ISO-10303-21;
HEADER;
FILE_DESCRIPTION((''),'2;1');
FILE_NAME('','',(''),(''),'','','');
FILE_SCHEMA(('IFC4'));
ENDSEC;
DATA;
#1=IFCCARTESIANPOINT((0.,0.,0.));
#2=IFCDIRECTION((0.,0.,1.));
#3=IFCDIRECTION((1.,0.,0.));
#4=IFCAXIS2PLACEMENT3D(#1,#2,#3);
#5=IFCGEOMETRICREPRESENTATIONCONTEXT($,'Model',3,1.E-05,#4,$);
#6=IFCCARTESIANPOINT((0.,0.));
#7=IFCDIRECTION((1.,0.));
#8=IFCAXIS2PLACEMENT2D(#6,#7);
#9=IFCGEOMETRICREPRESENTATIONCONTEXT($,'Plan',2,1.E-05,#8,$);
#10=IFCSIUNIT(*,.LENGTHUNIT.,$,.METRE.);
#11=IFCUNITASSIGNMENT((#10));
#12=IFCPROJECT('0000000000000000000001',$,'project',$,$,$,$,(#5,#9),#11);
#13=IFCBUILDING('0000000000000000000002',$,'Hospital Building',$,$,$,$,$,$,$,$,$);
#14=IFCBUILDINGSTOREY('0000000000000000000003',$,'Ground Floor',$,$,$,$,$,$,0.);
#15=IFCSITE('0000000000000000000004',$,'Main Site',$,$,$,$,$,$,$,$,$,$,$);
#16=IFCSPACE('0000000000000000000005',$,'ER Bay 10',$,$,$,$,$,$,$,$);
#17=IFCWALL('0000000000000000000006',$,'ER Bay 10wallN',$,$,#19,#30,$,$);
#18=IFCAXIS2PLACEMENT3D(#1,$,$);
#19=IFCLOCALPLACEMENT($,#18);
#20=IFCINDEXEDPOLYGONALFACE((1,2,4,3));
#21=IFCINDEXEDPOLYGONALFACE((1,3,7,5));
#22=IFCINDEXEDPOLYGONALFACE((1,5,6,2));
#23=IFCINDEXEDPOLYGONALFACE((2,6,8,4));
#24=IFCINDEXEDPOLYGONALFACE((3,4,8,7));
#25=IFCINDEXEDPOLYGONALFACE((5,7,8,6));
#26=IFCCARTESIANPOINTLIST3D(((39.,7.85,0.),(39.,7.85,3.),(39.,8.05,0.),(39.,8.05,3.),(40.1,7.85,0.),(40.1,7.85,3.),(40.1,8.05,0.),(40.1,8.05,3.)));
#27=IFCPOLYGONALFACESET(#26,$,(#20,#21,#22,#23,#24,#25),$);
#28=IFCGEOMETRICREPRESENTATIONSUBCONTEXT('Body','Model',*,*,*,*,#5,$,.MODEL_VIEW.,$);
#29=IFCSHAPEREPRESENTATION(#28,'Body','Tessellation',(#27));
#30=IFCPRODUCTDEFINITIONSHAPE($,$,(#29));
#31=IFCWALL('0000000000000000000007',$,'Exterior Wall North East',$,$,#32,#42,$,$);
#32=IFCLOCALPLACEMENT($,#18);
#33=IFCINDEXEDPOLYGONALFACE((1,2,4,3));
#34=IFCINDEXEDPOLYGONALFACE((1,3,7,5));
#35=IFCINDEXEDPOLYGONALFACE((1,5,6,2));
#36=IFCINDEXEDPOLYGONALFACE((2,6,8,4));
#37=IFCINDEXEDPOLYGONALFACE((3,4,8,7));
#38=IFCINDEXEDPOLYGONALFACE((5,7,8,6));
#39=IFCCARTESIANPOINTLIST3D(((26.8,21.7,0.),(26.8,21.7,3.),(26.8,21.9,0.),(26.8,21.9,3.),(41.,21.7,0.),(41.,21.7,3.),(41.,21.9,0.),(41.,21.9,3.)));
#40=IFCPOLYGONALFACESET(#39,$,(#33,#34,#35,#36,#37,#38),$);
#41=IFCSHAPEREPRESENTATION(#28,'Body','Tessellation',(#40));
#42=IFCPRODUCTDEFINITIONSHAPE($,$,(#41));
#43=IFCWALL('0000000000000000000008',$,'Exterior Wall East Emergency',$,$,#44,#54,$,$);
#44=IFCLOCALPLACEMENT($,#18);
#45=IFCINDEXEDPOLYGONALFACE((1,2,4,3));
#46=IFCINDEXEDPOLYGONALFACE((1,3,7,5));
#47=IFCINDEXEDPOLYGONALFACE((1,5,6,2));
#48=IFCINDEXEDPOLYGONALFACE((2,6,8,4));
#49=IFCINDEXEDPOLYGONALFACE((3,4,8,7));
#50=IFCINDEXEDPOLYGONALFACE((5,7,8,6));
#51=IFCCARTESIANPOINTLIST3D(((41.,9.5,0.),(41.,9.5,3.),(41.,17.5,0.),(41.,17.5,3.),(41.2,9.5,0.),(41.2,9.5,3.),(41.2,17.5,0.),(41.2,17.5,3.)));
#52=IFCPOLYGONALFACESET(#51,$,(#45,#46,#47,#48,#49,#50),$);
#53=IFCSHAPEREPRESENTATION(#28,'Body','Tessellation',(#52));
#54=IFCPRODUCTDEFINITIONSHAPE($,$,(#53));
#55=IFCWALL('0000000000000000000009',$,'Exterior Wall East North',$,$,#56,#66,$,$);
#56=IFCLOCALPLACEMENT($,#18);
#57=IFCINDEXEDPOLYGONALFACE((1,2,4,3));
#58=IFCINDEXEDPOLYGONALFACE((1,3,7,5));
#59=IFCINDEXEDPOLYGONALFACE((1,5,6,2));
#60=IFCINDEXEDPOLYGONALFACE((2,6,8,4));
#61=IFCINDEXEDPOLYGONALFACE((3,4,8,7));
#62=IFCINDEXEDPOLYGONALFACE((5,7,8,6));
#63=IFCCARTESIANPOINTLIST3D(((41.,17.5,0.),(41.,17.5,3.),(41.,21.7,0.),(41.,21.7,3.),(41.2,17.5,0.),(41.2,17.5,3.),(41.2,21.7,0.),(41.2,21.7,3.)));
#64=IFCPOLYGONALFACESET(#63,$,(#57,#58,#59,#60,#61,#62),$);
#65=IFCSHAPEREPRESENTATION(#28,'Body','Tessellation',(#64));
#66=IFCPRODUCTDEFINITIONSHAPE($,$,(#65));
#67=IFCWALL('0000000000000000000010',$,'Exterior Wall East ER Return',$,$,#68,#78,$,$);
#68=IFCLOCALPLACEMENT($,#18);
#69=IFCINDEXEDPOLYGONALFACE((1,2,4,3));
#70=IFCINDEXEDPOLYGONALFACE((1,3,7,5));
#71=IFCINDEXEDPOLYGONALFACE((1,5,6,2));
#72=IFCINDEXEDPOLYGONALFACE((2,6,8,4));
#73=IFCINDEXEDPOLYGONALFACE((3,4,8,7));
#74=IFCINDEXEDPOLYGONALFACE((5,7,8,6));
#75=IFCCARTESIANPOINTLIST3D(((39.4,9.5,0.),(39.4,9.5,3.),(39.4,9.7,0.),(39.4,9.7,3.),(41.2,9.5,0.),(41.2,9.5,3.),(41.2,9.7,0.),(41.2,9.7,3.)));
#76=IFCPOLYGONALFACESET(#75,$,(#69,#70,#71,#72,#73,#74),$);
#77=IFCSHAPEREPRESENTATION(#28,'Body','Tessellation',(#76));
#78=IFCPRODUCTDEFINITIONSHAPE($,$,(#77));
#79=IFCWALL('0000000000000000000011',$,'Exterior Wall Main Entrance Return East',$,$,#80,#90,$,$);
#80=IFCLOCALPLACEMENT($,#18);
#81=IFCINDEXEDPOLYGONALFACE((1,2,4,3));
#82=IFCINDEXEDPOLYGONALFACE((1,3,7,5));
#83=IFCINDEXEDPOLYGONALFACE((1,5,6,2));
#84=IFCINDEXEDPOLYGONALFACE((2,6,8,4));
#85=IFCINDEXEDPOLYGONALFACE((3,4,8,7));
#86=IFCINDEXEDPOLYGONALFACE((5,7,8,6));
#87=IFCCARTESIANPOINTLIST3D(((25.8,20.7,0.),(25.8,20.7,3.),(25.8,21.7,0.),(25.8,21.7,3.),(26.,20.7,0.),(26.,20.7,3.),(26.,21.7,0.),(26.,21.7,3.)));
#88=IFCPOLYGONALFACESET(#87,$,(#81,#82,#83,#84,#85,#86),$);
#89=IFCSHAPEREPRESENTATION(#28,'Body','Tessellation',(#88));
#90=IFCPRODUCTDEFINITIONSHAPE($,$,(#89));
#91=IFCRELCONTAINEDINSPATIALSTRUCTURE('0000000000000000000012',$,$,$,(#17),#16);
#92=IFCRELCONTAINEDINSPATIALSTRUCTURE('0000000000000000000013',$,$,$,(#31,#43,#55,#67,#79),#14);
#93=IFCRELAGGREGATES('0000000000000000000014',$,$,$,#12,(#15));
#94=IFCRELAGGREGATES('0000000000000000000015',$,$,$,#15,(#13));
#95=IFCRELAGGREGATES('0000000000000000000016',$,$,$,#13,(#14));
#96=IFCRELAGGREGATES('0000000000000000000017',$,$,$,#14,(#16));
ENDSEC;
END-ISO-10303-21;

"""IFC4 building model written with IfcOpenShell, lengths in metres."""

from ifc_helpers import new_model, si_unit, frame, origin_with_axes, origin_2d_with_axis, place, context, subcontext, project, spatial, indexed_curve, outline, extrude, element, save


model = new_model("IFC4")

# Units and contexts
model_context = context("Model", 3, precision=1e-05, world=origin_with_axes())
plan_context = context("Plan", 2, precision=1e-05, world=origin_2d_with_axis())
body_context = subcontext(model_context, "Body", "Model", "MODEL_VIEW")
ifc_project = project(units=[si_unit("LENGTHUNIT", "METRE")], contexts=[model_context, plan_context])

# Site, building, storey
site = spatial("IfcSite", under=ifc_project, Name="Main Site")
building = spatial("IfcBuilding", under=site, Name="Hospital Building")
storey = spatial("IfcBuildingStorey", under=building, Name="Ground Floor", Elevation=0.0)

# Shared definitions
space_1 = spatial("IfcSpace", under=storey, Name="ER Bay 10")

# Walls
wall_1_placement = place(None, frame((39.0, 7.85, 0.0), z_axis=(0.0, 0.0, 1.0), x_axis=(1.0, 0.0, 0.0)))
element("IfcWall", 1, at=wall_1_placement, inside=space_1, Name="ER Bay 10wallN", context=body_context, shape_type="SweptSolid", body=[
    extrude(outline(indexed_curve([(0.0, 0.0), (0.0, 0.2), (1.1, 0.2), (1.1, 0.0), (0.0, 0.0)], self_intersect=False)), origin_with_axes(), (0.0, 0.0, 1.0), 3.0),
])
wall_2_placement = place(None, frame((26.8, 21.7, 0.0), z_axis=(0.0, 0.0, 1.0), x_axis=(1.0, 0.0, 0.0)))
element("IfcWall", 2, at=wall_2_placement, inside=storey, Name="Exterior Wall North East", context=body_context, shape_type="SweptSolid", body=[
    extrude(outline(indexed_curve([(0.0, 0.0), (0.0, 0.2), (14.2, 0.2), (14.2, 0.0), (0.0, 0.0)], self_intersect=False)), origin_with_axes(), (0.0, 0.0, 1.0), 3.0),
])
wall_3_placement = place(None, frame((41.2, 9.5, 0.0), z_axis=(0.0, 0.0, 1.0), x_axis=(0.0, 1.0, 0.0)))
element("IfcWall", 3, at=wall_3_placement, inside=storey, Name="Exterior Wall East Emergency", context=body_context, shape_type="SweptSolid", body=[
    extrude(outline(indexed_curve([(0.0, 0.0), (0.0, 0.2), (8.0, 0.2), (8.0, 0.0), (0.0, 0.0)], self_intersect=False)), origin_with_axes(), (0.0, 0.0, 1.0), 3.0),
])
wall_4_placement = place(None, frame((41.2, 17.5, 0.0), z_axis=(0.0, 0.0, 1.0), x_axis=(0.0, 1.0, 0.0)))
element("IfcWall", 4, at=wall_4_placement, inside=storey, Name="Exterior Wall East North", context=body_context, shape_type="SweptSolid", body=[
    extrude(outline(indexed_curve([(0.0, 0.0), (0.0, 0.2), (4.2, 0.2), (4.2, 0.0), (0.0, 0.0)], self_intersect=False)), origin_with_axes(), (0.0, 0.0, 1.0), 3.0),
])
wall_5_placement = place(None, frame((39.4, 9.5, 0.0), z_axis=(0.0, 0.0, 1.0), x_axis=(1.0, 0.0, 0.0)))
element("IfcWall", 5, at=wall_5_placement, inside=storey, Name="Exterior Wall East ER Return", context=body_context, shape_type="SweptSolid", body=[
    extrude(outline(indexed_curve([(0.0, 0.0), (0.0, 0.2), (1.8, 0.2), (1.8, 0.0), (0.0, 0.0)], self_intersect=False)), origin_with_axes(), (0.0, 0.0, 1.0), 3.0),
])
wall_6_placement = place(None, frame((26.0, 20.7, 0.0), z_axis=(0.0, 0.0, 1.0), x_axis=(0.0, 1.0, 0.0)))
element("IfcWall", 6, at=wall_6_placement, inside=storey, Name="Exterior Wall Main Entrance Return East", context=body_context, shape_type="SweptSolid", body=[
    extrude(outline(indexed_curve([(0.0, 0.0), (0.0, 0.2), (1.0, 0.2), (1.0, 0.0), (0.0, 0.0)], self_intersect=False)), origin_with_axes(), (0.0, 0.0, 1.0), 3.0),
])

save(model, "model.ifc")
